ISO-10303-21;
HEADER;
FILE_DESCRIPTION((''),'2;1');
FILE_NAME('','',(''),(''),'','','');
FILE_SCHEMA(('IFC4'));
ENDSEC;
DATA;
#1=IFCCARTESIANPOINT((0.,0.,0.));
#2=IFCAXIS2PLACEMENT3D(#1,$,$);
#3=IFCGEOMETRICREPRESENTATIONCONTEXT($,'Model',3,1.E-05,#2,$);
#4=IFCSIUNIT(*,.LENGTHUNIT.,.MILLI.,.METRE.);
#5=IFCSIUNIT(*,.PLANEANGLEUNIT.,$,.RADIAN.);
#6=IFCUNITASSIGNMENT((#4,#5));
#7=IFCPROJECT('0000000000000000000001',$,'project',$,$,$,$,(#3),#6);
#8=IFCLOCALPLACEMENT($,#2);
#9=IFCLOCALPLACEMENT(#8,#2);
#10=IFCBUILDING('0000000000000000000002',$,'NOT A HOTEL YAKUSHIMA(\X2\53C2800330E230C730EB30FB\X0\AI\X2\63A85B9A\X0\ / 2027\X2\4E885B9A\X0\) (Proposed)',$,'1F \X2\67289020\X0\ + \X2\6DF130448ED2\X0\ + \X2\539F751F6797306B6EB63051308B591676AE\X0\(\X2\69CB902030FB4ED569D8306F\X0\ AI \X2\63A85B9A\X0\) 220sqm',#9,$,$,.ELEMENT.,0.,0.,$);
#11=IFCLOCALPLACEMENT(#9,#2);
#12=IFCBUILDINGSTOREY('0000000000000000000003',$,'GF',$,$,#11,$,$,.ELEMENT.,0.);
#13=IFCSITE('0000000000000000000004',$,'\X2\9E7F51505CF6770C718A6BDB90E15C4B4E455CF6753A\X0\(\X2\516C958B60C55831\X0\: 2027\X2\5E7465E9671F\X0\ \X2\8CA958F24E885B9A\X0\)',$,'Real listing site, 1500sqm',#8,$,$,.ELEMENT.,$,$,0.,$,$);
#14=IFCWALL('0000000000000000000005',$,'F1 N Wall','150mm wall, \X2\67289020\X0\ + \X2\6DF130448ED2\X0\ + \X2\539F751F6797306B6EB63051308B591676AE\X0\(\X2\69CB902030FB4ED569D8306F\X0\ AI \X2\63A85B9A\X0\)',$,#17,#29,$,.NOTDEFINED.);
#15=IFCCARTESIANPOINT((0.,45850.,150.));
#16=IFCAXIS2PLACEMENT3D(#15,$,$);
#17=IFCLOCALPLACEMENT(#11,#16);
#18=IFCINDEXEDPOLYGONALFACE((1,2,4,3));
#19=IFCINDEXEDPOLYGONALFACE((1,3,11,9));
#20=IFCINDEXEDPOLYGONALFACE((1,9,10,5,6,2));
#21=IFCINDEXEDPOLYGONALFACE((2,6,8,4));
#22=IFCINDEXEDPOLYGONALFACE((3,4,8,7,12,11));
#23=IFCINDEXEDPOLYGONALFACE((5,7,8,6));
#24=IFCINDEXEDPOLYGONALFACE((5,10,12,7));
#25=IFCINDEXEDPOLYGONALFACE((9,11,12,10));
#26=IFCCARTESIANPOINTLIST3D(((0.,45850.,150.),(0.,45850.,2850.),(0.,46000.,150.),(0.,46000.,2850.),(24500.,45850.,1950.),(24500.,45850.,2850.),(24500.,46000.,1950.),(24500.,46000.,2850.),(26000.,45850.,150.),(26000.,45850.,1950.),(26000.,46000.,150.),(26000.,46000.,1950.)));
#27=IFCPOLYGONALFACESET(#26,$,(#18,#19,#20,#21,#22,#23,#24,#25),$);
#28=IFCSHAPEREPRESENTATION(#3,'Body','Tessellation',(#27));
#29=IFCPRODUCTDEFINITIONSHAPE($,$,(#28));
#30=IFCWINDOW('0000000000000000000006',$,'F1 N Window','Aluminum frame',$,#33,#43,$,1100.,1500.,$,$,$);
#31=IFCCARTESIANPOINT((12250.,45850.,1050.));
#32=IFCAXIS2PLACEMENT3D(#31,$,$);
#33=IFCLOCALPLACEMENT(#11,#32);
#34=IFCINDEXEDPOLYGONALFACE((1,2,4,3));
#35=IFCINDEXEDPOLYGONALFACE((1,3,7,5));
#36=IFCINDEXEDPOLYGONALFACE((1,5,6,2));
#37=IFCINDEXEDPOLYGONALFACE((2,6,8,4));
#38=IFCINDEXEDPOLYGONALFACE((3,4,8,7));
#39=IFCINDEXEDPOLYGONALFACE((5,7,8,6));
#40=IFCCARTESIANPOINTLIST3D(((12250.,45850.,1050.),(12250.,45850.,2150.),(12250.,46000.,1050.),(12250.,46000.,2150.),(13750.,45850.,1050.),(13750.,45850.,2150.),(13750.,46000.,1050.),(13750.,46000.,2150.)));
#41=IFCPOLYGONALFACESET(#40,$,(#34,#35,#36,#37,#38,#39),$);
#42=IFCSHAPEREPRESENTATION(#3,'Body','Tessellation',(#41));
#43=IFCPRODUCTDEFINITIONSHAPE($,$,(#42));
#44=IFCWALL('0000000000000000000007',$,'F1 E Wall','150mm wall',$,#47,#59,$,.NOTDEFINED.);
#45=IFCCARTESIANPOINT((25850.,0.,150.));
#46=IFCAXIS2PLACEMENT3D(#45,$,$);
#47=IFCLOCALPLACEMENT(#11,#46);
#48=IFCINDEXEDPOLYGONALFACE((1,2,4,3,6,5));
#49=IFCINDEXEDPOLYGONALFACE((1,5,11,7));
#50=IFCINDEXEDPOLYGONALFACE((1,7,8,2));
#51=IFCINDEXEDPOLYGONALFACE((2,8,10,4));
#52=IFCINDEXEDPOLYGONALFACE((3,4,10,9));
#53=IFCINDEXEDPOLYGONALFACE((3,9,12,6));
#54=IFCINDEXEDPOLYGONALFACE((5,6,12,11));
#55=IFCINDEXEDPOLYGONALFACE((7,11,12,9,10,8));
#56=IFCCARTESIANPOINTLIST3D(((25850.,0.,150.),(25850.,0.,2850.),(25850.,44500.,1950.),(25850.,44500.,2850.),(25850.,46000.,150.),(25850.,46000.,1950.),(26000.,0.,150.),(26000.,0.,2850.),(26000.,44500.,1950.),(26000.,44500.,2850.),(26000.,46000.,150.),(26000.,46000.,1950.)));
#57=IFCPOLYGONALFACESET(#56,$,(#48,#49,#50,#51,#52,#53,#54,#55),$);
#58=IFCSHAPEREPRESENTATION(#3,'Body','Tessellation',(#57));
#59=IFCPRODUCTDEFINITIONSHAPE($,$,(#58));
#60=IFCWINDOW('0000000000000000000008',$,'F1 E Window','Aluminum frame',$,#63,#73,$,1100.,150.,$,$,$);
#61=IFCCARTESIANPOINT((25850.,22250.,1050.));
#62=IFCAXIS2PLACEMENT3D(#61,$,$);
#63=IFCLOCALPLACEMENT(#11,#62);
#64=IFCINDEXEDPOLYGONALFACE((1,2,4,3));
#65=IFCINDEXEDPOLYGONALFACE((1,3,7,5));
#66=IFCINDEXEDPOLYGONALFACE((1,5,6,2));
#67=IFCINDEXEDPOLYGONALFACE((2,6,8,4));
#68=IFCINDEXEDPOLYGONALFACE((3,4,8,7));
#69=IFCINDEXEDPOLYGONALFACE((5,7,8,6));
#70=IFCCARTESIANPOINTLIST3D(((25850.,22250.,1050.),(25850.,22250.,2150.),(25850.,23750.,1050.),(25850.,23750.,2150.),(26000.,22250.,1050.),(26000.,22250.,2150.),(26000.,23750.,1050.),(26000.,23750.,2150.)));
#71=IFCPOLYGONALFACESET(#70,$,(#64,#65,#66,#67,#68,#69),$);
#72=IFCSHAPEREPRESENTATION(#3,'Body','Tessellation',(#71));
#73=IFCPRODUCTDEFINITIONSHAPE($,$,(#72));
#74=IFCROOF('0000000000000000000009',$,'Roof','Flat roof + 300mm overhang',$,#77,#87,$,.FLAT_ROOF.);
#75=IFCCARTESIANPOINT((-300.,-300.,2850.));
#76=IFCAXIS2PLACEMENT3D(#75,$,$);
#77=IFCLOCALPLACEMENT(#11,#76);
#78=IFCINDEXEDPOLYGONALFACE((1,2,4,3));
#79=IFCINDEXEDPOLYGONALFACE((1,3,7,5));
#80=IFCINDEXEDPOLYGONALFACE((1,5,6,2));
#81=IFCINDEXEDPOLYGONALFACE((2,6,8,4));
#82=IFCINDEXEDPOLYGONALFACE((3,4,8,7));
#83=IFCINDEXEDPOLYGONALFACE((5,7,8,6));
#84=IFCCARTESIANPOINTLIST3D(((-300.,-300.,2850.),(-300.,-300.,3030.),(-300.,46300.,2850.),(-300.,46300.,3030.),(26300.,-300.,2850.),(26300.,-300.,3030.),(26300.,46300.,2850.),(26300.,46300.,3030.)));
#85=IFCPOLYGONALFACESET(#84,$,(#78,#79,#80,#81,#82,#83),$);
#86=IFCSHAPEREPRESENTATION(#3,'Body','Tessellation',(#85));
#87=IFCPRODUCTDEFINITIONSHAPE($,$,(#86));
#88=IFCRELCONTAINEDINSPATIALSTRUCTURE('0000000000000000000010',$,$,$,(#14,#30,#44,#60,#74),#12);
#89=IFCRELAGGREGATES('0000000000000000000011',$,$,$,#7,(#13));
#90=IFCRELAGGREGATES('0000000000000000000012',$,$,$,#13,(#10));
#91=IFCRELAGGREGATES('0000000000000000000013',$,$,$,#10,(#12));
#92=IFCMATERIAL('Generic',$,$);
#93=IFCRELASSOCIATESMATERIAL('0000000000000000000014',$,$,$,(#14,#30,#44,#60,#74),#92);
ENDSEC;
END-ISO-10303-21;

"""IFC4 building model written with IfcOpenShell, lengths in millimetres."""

from ifc_helpers import new_model, si_unit, frame, frame_2d, origin, place, context, project, spatial, rectangle, extrude, material, element, fill, save


model = new_model("IFC4")

# Units and contexts
model_context = context("Model", 3, precision=1e-05, world=origin())
ifc_project = project(units=[si_unit("LENGTHUNIT", "METRE", prefix="MILLI"), si_unit("PLANEANGLEUNIT", "RADIAN")], contexts=[model_context])

# Site, building, storey
site_placement = place(None, origin())
site = spatial("IfcSite", under=ifc_project, at=site_placement, Name="鹿児島県熊毛郡屋久島町(公開情報: 2027年早期 販売予定)", ObjectType="Real listing site, 1500sqm", CompositionType="ELEMENT", RefElevation=0.0)
building_placement = place(site_placement, origin())
building = spatial("IfcBuilding", under=site, at=building_placement, Name="NOT A HOTEL YAKUSHIMA(参考モデル・AI推定 / 2027予定) (Proposed)", ObjectType="1F 木造 + 深い軒 + 原生林に溶ける外皮(構造・仕様は AI 推定) 220sqm", CompositionType="ELEMENT", ElevationOfRefHeight=0.0, ElevationOfTerrain=0.0)
storey_placement = place(building_placement, origin())
storey = spatial("IfcBuildingStorey", under=building, at=storey_placement, Name="GF", CompositionType="ELEMENT", Elevation=0.0)

# Wall, opening, window
ifc_material_1 = material(Name="Generic")
wall_1_placement = place(storey_placement, frame((0.0, 45850.0, 150.0)))
wall_1 = element("IfcWall", 1, at=wall_1_placement, inside=storey, material=ifc_material_1, Name="F1 N Wall", Description="150mm wall, 木造 + 深い軒 + 原生林に溶ける外皮(構造・仕様は AI 推定)", PredefinedType="NOTDEFINED", context=model_context, shape_type="SweptSolid", body=[
    extrude(rectangle(XDim=26000.0, YDim=150.0, at=frame_2d((13000.0, 75.0))), frame((0.0, 45850.0, 150.0)), (0.0, 0.0, 1.0), 2700.0),
])
opening_1_placement = place(storey_placement, frame((12250.0, 45850.0, 1050.0)))
opening_1 = element("IfcOpeningElement", 2, at=opening_1_placement, cuts=wall_1, PredefinedType="NOTDEFINED", context=model_context, shape_type="SweptSolid", body=[
    extrude(rectangle(XDim=1500.0, YDim=150.0, at=frame_2d((750.0, 75.0))), frame((12250.0, 45850.0, 1050.0)), (0.0, 0.0, 1.0), 1100.0),
])
window_1_placement = place(storey_placement, frame((12250.0, 45850.0, 1050.0)))
window_1 = element("IfcWindow", 3, at=window_1_placement, inside=storey, material=ifc_material_1, Name="F1 N Window", Description="Aluminum frame", OverallHeight=1100.0, OverallWidth=1500.0, context=model_context, shape_type="SweptSolid", body=[
    extrude(rectangle(XDim=1500.0, YDim=150.0, at=frame_2d((750.0, 75.0))), frame((12250.0, 45850.0, 1050.0)), (0.0, 0.0, 1.0), 1100.0),
])
fill(opening_1, window_1)

# Wall, opening, window
wall_2_placement = place(storey_placement, frame((25850.0, 0.0, 150.0)))
wall_2 = element("IfcWall", 4, at=wall_2_placement, inside=storey, material=ifc_material_1, Name="F1 E Wall", Description="150mm wall", PredefinedType="NOTDEFINED", context=model_context, shape_type="SweptSolid", body=[
    extrude(rectangle(XDim=150.0, YDim=46000.0, at=frame_2d((75.0, 23000.0))), frame((25850.0, 0.0, 150.0)), (0.0, 0.0, 1.0), 2700.0),
])
opening_2_placement = place(storey_placement, frame((25850.0, 22250.0, 1050.0)))
opening_2 = element("IfcOpeningElement", 5, at=opening_2_placement, cuts=wall_2, PredefinedType="NOTDEFINED", context=model_context, shape_type="SweptSolid", body=[
    extrude(rectangle(XDim=150.0, YDim=1500.0, at=frame_2d((75.0, 750.0))), frame((25850.0, 22250.0, 1050.0)), (0.0, 0.0, 1.0), 1100.0),
])
window_2_placement = place(storey_placement, frame((25850.0, 22250.0, 1050.0)))
window_2 = element("IfcWindow", 6, at=window_2_placement, inside=storey, material=ifc_material_1, Name="F1 E Window", Description="Aluminum frame", OverallHeight=1100.0, OverallWidth=150.0, context=model_context, shape_type="SweptSolid", body=[
    extrude(rectangle(XDim=150.0, YDim=1500.0, at=frame_2d((75.0, 750.0))), frame((25850.0, 22250.0, 1050.0)), (0.0, 0.0, 1.0), 1100.0),
])
fill(opening_2, window_2)

# Roof
roof_placement = place(storey_placement, frame((-300.0, -300.0, 2850.0)))
element("IfcRoof", 7, at=roof_placement, inside=storey, material=ifc_material_1, Name="Roof", Description="Flat roof + 300mm overhang", PredefinedType="FLAT_ROOF", context=model_context, shape_type="SweptSolid", body=[
    extrude(rectangle(XDim=26600.0, YDim=46600.0, at=frame_2d((13300.0, 23300.0))), frame((-300.0, -300.0, 2850.0)), (0.0, 0.0, 1.0), 180.0),
])

save(model, "model.ifc")
